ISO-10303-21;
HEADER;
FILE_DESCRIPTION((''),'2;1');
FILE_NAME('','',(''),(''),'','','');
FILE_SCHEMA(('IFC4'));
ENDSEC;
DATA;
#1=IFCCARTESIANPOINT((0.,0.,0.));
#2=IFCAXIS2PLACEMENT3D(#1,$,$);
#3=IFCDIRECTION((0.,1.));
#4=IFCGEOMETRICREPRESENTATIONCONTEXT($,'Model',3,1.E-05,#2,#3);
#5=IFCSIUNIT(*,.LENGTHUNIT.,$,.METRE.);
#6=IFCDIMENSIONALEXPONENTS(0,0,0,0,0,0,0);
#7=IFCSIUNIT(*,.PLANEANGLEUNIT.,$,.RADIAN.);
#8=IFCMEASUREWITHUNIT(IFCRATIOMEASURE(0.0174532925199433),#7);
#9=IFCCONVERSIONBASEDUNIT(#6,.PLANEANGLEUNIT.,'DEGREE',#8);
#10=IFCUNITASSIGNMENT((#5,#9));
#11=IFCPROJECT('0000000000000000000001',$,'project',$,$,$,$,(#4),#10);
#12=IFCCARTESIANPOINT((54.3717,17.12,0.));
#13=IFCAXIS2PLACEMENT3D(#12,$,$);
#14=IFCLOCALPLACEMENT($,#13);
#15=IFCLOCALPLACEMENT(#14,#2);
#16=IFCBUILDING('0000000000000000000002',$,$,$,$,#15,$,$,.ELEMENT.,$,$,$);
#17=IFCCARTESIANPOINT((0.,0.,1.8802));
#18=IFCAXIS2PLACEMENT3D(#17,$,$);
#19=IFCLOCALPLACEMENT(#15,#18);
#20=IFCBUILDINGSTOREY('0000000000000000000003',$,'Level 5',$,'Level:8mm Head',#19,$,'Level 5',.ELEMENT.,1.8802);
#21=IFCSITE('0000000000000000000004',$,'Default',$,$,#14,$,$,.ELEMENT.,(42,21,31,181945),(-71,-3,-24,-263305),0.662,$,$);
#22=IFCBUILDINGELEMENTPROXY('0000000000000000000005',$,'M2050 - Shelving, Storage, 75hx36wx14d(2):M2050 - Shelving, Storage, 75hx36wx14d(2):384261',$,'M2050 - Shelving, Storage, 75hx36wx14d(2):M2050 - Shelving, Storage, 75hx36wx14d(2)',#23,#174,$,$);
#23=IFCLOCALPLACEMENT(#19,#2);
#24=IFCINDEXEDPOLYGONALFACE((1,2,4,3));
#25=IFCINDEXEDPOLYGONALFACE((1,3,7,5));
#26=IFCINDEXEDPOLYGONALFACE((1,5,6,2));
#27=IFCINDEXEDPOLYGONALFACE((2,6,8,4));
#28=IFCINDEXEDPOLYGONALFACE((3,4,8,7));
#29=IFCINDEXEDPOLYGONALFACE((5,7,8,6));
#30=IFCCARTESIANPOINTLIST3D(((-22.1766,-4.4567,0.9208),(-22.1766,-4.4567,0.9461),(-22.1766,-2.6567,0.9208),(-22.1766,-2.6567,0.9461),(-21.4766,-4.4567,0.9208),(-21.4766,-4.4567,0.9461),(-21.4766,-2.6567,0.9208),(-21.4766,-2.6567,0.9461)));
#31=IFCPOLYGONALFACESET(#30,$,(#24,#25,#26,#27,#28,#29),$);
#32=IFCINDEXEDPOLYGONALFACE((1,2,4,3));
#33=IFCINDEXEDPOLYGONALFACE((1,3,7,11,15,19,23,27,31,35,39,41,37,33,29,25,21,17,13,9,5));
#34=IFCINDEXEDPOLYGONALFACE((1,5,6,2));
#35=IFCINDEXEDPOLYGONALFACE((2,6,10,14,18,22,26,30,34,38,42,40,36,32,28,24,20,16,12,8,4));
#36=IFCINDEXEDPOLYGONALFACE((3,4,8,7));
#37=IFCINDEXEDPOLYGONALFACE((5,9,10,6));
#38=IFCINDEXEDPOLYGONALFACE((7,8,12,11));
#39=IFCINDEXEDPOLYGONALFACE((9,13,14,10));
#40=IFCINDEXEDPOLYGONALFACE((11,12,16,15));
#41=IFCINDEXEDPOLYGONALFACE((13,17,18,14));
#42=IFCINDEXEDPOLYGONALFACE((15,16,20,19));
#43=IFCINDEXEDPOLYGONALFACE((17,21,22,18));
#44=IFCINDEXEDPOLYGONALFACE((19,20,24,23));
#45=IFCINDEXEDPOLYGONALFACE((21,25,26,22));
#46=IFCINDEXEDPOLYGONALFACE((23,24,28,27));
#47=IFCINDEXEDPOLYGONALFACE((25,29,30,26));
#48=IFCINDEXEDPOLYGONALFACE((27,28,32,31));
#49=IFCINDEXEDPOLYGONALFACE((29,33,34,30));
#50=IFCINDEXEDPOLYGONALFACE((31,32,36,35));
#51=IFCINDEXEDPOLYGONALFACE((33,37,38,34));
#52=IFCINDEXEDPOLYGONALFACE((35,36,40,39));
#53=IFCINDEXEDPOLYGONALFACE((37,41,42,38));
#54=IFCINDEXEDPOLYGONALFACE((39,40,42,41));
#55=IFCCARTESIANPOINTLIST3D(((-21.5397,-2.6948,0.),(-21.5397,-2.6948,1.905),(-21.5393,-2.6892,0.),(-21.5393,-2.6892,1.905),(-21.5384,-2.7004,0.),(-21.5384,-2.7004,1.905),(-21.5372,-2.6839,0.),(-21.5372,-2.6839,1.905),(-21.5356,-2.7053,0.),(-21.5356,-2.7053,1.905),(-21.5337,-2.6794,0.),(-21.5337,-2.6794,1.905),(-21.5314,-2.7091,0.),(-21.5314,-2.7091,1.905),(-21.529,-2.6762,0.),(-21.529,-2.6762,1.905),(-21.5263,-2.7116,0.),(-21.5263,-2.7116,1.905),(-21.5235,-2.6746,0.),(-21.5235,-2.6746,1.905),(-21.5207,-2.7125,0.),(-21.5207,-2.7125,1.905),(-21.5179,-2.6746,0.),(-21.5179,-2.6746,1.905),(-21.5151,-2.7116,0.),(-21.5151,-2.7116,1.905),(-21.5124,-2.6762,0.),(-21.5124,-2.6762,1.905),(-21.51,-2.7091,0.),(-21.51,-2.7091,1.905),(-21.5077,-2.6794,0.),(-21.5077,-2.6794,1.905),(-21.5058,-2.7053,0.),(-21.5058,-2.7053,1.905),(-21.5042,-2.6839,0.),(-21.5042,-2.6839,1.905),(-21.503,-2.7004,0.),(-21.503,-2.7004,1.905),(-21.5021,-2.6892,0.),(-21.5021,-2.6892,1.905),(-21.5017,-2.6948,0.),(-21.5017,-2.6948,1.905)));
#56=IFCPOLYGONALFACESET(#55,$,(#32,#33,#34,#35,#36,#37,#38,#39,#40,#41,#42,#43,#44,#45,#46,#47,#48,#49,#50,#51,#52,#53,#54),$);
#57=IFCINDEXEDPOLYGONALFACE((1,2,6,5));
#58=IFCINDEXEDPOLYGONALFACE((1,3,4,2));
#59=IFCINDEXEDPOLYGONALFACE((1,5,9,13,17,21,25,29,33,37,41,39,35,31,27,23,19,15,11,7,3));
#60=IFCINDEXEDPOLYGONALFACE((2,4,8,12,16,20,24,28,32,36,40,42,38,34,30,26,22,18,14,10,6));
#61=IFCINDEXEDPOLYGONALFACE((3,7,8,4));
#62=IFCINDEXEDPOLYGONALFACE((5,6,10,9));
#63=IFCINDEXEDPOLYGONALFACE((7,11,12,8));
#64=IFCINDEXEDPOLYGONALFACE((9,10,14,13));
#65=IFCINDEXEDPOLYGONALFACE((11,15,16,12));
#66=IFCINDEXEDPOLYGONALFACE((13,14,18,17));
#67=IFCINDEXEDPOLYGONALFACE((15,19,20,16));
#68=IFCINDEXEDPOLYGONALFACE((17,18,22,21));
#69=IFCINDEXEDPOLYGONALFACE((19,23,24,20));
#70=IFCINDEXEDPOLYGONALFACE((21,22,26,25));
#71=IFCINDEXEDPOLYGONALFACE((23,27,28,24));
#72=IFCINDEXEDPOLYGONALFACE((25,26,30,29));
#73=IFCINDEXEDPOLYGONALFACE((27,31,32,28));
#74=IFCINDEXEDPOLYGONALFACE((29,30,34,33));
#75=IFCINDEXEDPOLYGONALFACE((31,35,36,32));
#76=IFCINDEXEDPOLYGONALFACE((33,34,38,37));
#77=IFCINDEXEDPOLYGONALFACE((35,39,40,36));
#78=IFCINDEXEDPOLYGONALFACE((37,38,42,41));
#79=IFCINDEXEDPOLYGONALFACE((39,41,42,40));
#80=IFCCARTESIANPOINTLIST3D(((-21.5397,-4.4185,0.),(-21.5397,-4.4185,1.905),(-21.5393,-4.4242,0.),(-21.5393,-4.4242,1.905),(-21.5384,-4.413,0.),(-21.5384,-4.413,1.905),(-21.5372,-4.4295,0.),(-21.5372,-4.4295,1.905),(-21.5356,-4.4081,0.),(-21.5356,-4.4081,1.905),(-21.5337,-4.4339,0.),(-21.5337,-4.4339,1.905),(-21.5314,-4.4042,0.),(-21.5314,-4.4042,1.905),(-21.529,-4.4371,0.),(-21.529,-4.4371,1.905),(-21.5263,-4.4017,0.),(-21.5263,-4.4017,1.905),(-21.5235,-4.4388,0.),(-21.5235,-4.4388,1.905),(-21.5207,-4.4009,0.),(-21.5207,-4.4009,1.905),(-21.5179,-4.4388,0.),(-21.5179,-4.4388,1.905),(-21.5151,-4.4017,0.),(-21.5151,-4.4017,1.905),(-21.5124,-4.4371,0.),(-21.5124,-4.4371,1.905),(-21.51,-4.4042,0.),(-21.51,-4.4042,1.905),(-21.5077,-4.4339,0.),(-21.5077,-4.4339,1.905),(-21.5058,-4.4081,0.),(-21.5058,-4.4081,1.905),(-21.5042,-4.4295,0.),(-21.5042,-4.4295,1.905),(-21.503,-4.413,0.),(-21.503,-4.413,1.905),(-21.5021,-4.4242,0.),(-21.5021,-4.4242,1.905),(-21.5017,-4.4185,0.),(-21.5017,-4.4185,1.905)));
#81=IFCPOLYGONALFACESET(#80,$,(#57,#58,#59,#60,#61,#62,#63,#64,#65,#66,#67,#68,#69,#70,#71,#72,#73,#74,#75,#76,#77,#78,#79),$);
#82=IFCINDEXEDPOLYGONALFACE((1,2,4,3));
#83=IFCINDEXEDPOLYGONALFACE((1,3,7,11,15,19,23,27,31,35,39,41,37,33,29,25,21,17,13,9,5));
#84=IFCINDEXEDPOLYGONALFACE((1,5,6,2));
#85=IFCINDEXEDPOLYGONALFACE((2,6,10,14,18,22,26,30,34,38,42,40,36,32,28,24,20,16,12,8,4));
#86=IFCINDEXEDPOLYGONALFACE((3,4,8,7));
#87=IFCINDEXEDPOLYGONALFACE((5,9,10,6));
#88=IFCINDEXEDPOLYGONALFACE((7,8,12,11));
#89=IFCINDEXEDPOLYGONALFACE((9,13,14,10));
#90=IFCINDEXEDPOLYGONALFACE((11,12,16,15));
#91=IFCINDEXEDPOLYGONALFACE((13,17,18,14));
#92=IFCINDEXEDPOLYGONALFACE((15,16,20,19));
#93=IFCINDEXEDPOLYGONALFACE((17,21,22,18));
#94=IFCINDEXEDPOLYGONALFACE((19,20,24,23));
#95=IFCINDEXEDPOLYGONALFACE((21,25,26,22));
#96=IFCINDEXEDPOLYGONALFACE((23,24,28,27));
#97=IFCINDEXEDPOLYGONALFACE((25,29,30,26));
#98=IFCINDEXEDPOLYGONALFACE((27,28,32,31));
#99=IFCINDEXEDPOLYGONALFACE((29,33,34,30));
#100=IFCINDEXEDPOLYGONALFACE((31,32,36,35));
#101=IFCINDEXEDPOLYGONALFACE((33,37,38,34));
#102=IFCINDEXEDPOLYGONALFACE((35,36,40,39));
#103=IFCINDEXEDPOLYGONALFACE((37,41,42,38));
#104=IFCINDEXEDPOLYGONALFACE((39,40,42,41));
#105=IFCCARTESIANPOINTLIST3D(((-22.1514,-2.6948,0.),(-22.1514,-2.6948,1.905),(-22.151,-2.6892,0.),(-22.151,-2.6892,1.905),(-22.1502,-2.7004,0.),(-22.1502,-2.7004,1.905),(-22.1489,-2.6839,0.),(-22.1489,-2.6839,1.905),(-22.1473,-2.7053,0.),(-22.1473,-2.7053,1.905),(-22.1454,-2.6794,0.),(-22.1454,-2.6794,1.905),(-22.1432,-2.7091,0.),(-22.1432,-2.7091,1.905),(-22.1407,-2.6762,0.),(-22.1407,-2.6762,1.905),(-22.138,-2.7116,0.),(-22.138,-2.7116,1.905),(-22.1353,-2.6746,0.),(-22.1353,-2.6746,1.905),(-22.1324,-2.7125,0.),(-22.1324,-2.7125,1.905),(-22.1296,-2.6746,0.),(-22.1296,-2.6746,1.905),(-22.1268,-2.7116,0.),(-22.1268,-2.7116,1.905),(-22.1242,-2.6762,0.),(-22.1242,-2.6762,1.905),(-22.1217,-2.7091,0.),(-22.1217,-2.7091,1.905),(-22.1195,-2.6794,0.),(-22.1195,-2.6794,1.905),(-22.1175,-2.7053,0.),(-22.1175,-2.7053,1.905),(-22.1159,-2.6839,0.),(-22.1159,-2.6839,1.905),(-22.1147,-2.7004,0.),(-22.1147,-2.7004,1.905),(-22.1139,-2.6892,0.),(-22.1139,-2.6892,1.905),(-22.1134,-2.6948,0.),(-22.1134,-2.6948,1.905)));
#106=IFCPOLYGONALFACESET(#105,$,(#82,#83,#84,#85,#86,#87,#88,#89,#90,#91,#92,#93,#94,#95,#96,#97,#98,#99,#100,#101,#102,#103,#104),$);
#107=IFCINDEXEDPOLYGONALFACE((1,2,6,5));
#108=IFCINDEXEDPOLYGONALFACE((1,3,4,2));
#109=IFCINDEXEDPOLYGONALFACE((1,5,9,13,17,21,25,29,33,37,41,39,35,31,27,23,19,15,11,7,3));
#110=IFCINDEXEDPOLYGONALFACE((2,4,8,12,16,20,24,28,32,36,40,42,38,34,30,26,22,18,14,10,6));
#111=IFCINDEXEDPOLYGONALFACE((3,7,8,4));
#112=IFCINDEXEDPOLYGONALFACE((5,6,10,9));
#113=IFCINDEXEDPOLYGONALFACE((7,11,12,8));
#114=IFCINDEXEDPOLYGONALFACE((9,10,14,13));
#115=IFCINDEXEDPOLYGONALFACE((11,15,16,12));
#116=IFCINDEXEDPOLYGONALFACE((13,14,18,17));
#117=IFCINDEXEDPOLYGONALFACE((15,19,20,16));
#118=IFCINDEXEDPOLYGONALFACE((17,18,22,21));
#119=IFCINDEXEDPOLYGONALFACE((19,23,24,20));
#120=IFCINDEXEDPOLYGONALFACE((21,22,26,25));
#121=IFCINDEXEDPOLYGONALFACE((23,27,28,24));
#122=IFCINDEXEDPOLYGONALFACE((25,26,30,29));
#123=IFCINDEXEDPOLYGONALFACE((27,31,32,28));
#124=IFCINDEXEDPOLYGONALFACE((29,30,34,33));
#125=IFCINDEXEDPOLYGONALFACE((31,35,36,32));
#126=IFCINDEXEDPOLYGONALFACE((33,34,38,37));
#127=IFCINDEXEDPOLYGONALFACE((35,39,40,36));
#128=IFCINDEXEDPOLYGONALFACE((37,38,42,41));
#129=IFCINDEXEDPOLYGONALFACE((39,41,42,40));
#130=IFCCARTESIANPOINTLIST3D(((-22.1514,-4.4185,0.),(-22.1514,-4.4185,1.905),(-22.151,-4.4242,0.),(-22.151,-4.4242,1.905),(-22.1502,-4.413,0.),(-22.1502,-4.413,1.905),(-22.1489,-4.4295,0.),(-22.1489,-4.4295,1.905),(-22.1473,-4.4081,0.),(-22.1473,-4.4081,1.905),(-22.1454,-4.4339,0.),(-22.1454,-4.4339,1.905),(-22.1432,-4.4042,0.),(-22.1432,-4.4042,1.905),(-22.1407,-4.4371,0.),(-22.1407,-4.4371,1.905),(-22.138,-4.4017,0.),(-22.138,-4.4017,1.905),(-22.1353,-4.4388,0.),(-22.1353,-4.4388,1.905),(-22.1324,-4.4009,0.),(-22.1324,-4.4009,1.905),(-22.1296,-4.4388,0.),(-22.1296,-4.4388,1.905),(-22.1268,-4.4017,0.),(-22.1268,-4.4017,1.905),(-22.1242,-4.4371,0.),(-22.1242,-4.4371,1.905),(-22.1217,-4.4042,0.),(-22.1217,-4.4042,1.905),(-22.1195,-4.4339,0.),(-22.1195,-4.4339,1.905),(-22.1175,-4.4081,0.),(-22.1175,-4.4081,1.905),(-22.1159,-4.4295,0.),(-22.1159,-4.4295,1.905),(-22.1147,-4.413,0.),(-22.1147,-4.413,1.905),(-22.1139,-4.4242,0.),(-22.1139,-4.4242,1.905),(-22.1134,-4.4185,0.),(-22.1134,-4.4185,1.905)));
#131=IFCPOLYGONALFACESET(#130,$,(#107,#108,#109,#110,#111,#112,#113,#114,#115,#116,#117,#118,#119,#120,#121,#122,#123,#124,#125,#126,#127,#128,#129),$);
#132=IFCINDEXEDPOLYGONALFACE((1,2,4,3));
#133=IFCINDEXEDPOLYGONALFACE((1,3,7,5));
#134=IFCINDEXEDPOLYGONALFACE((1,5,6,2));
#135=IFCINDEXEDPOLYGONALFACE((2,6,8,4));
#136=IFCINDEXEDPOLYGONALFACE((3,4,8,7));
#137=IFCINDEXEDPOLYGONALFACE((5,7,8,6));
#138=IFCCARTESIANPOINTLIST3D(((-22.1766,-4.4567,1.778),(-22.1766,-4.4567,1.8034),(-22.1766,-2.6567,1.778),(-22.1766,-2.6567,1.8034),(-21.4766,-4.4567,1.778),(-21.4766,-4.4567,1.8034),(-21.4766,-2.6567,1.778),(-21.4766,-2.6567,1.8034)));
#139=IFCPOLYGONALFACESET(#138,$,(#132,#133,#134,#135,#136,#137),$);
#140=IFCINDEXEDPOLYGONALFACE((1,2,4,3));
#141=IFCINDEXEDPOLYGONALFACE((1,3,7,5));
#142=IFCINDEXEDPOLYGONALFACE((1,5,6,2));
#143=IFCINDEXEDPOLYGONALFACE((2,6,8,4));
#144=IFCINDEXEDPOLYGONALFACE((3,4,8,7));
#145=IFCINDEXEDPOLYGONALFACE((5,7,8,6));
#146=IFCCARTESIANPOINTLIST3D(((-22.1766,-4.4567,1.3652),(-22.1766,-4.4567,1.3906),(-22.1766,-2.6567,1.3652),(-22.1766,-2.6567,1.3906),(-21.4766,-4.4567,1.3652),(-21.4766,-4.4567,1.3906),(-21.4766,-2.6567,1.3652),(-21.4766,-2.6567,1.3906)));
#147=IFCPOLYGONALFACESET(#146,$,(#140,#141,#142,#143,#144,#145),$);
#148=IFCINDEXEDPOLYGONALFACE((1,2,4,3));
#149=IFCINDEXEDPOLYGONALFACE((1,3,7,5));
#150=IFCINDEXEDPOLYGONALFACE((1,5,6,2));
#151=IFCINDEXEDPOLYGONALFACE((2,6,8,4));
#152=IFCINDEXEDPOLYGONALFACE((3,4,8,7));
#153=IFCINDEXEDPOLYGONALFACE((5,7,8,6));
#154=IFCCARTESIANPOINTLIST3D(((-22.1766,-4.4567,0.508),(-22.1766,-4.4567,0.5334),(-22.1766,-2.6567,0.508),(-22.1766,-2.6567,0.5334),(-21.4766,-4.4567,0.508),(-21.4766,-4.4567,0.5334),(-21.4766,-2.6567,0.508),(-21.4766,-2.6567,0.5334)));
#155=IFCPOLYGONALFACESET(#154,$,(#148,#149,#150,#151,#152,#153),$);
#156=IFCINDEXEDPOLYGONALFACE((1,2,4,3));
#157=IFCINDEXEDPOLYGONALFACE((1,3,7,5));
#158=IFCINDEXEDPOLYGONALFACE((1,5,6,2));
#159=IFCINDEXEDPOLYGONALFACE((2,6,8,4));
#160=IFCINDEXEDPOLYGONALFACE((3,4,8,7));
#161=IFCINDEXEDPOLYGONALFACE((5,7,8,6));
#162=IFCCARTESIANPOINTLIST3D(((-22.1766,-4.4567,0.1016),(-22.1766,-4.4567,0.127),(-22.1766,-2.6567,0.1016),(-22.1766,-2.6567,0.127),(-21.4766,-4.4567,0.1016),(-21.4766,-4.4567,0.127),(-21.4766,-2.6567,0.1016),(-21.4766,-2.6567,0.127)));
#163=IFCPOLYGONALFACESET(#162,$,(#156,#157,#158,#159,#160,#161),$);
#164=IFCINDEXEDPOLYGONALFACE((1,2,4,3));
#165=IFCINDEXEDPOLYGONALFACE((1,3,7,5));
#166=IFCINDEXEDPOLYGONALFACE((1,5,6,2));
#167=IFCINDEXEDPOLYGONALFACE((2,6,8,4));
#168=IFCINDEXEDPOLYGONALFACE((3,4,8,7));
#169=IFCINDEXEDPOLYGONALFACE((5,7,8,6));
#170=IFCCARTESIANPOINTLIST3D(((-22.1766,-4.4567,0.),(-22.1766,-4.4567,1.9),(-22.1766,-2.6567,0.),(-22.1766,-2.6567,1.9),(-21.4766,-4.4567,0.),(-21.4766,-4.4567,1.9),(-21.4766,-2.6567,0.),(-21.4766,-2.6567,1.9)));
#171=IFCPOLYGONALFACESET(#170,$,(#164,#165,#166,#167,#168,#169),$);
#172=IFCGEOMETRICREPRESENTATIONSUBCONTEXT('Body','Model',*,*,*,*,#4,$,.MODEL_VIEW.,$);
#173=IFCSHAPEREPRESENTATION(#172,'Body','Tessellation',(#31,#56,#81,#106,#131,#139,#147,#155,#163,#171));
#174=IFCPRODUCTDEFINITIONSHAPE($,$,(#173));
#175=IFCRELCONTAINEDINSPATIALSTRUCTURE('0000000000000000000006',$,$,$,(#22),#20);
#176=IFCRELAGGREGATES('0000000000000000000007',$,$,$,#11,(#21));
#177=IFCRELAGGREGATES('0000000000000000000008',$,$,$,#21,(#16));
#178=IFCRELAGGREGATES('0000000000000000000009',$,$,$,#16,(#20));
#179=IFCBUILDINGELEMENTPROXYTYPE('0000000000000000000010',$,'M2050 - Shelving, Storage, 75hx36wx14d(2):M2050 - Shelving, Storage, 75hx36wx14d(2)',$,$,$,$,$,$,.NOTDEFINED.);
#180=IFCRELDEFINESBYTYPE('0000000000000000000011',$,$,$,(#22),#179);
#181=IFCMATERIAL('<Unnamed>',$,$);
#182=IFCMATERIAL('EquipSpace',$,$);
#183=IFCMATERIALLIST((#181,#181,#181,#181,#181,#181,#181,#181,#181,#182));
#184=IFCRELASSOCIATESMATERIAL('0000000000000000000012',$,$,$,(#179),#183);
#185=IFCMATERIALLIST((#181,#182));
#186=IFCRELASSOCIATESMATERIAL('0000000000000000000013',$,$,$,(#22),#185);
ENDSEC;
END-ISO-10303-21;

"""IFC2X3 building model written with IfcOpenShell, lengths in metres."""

from ifc_helpers import new_model, entity, si_unit, converted_unit, direction, frame, frame_2d, origin, origin_2d_with_axis, place, context, subcontext, project, spatial, rectangle, circle, extrude, source, transform, mapped, material, material_list, type_object, type_shapes, element, save


model = new_model("IFC2X3")

# Units and contexts
model_context = context("Model", 3, precision=1e-05, world=origin(), true_north=direction((0.0, 1.0)))
body_context = subcontext(model_context, "Body", "Model", "MODEL_VIEW")
ifc_project = project(units=[si_unit("LENGTHUNIT", "METRE"), converted_unit("PLANEANGLEUNIT", "DEGREE", entity("IfcRatioMeasure", 0.0174532925199433), si_unit("PLANEANGLEUNIT", "RADIAN"), dimensions=[0, 0, 0, 0, 0, 0, 0])], contexts=[model_context])

# Site, building, storey
site_placement = place(None, frame((54.3717, 17.12, 0.0)))
site = spatial("IfcSite", under=ifc_project, at=site_placement, Name="Default", CompositionType="ELEMENT", RefLatitude=(42, 21, 31, 181945), RefLongitude=(-71, -3, -24, -263305), RefElevation=0.662)
building_placement = place(site_placement, origin())
building = spatial("IfcBuilding", under=site, at=building_placement, CompositionType="ELEMENT")
storey_placement = place(building_placement, frame((0.0, 0.0, 1.8802)))
storey = spatial("IfcBuildingStorey", under=building, at=storey_placement, Name="Level 5", ObjectType="Level:8mm Head", LongName="Level 5", CompositionType="ELEMENT", Elevation=1.8802)

# Building element proxy
ifc_material_1 = material(Name="<Unnamed>")
ifc_material_2 = material(Name="EquipSpace")
ifc_material_list_1 = material_list([ifc_material_1, ifc_material_2])
ifc_material_list_2 = material_list([ifc_material_1, ifc_material_1, ifc_material_1, ifc_material_1, ifc_material_1, ifc_material_1, ifc_material_1, ifc_material_1, ifc_material_1, ifc_material_2])
building_element_proxy_type = type_object("IfcBuildingElementProxyType", Name="M2050 - Shelving, Storage, 75hx36wx14d(2):M2050 - Shelving, Storage, 75hx36wx14d(2)", PredefinedType="NOTDEFINED", material=ifc_material_list_2)
shared_shape = source(origin(), body_context, "Body", "SweptSolid", [
    extrude(rectangle(XDim=1.8, YDim=0.7, at=origin_2d_with_axis()), frame((0.0, 0.0, 0.9207), z_axis=(0.0, 0.0, 1.0), x_axis=(-1.0, 0.0, 0.0)), (0.0, 0.0, 1.0), 0.0254),
    extrude(circle(Radius=0.0191, at=origin_2d_with_axis()), frame((0.8633, -0.3059, 0.0), z_axis=(0.0, 0.0, 1.0), x_axis=(-1.0, 0.0, 0.0)), (0.0, 0.0, 1.0), 1.905),
    extrude(circle(Radius=0.0191, at=origin_2d_with_axis()), frame((-0.8633, -0.3059, 0.0)), (0.0, 0.0, 1.0), 1.905),
    extrude(circle(Radius=0.0191, at=origin_2d_with_axis()), frame((0.8633, 0.3059, 0.0), z_axis=(0.0, 0.0, 1.0), x_axis=(-1.0, 0.0, 0.0)), (0.0, 0.0, 1.0), 1.905),
    extrude(circle(Radius=0.0191, at=origin_2d_with_axis()), frame((-0.8633, 0.3059, 0.0)), (0.0, 0.0, 1.0), 1.905),
    extrude(rectangle(XDim=1.8, YDim=0.7, at=origin_2d_with_axis()), frame((0.0, 0.0, 1.778), z_axis=(0.0, 0.0, 1.0), x_axis=(-1.0, 0.0, 0.0)), (0.0, 0.0, 1.0), 0.0254),
    extrude(rectangle(XDim=1.8, YDim=0.7, at=origin_2d_with_axis()), frame((0.0, 0.0, 1.3653), z_axis=(0.0, 0.0, 1.0), x_axis=(-1.0, 0.0, 0.0)), (0.0, 0.0, 1.0), 0.0254),
    extrude(rectangle(XDim=1.8, YDim=0.7, at=origin_2d_with_axis()), frame((0.0, 0.0, 0.508), z_axis=(0.0, 0.0, 1.0), x_axis=(-1.0, 0.0, 0.0)), (0.0, 0.0, 1.0), 0.0254),
    extrude(rectangle(XDim=1.8, YDim=0.7, at=origin_2d_with_axis()), frame((0.0, 0.0, 0.1016), z_axis=(0.0, 0.0, 1.0), x_axis=(-1.0, 0.0, 0.0)), (0.0, 0.0, 1.0), 0.0254),
    extrude(rectangle(XDim=0.7, YDim=1.8, at=frame_2d((0.0, 0.18), x_axis=(1.0, 0.0))), frame((-0.18, 0.0, 0.0), z_axis=(0.0, 0.0, 1.0), x_axis=(0.0, -1.0, 0.0)), (0.0, 0.0, 1.0), 1.9),
])
type_shapes(building_element_proxy_type, [shared_shape])
proxy_1_placement = place(storey_placement, frame((-21.8266, -3.5567, 0.0), z_axis=(0.0, 0.0, 1.0), x_axis=(0.0, 1.0, 0.0)))
element("IfcBuildingElementProxy", 1, at=proxy_1_placement, inside=storey, type_object=building_element_proxy_type, material=ifc_material_list_1, Name="M2050 - Shelving, Storage, 75hx36wx14d(2):M2050 - Shelving, Storage, 75hx36wx14d(2):384261", ObjectType="M2050 - Shelving, Storage, 75hx36wx14d(2):M2050 - Shelving, Storage, 75hx36wx14d(2)", context=body_context, shape_type="MappedRepresentation", body=[
    mapped(shared_shape, transform((0.0, 0.0, 0.0), scale=1.0)),
])

save(model, "model.ifc")
